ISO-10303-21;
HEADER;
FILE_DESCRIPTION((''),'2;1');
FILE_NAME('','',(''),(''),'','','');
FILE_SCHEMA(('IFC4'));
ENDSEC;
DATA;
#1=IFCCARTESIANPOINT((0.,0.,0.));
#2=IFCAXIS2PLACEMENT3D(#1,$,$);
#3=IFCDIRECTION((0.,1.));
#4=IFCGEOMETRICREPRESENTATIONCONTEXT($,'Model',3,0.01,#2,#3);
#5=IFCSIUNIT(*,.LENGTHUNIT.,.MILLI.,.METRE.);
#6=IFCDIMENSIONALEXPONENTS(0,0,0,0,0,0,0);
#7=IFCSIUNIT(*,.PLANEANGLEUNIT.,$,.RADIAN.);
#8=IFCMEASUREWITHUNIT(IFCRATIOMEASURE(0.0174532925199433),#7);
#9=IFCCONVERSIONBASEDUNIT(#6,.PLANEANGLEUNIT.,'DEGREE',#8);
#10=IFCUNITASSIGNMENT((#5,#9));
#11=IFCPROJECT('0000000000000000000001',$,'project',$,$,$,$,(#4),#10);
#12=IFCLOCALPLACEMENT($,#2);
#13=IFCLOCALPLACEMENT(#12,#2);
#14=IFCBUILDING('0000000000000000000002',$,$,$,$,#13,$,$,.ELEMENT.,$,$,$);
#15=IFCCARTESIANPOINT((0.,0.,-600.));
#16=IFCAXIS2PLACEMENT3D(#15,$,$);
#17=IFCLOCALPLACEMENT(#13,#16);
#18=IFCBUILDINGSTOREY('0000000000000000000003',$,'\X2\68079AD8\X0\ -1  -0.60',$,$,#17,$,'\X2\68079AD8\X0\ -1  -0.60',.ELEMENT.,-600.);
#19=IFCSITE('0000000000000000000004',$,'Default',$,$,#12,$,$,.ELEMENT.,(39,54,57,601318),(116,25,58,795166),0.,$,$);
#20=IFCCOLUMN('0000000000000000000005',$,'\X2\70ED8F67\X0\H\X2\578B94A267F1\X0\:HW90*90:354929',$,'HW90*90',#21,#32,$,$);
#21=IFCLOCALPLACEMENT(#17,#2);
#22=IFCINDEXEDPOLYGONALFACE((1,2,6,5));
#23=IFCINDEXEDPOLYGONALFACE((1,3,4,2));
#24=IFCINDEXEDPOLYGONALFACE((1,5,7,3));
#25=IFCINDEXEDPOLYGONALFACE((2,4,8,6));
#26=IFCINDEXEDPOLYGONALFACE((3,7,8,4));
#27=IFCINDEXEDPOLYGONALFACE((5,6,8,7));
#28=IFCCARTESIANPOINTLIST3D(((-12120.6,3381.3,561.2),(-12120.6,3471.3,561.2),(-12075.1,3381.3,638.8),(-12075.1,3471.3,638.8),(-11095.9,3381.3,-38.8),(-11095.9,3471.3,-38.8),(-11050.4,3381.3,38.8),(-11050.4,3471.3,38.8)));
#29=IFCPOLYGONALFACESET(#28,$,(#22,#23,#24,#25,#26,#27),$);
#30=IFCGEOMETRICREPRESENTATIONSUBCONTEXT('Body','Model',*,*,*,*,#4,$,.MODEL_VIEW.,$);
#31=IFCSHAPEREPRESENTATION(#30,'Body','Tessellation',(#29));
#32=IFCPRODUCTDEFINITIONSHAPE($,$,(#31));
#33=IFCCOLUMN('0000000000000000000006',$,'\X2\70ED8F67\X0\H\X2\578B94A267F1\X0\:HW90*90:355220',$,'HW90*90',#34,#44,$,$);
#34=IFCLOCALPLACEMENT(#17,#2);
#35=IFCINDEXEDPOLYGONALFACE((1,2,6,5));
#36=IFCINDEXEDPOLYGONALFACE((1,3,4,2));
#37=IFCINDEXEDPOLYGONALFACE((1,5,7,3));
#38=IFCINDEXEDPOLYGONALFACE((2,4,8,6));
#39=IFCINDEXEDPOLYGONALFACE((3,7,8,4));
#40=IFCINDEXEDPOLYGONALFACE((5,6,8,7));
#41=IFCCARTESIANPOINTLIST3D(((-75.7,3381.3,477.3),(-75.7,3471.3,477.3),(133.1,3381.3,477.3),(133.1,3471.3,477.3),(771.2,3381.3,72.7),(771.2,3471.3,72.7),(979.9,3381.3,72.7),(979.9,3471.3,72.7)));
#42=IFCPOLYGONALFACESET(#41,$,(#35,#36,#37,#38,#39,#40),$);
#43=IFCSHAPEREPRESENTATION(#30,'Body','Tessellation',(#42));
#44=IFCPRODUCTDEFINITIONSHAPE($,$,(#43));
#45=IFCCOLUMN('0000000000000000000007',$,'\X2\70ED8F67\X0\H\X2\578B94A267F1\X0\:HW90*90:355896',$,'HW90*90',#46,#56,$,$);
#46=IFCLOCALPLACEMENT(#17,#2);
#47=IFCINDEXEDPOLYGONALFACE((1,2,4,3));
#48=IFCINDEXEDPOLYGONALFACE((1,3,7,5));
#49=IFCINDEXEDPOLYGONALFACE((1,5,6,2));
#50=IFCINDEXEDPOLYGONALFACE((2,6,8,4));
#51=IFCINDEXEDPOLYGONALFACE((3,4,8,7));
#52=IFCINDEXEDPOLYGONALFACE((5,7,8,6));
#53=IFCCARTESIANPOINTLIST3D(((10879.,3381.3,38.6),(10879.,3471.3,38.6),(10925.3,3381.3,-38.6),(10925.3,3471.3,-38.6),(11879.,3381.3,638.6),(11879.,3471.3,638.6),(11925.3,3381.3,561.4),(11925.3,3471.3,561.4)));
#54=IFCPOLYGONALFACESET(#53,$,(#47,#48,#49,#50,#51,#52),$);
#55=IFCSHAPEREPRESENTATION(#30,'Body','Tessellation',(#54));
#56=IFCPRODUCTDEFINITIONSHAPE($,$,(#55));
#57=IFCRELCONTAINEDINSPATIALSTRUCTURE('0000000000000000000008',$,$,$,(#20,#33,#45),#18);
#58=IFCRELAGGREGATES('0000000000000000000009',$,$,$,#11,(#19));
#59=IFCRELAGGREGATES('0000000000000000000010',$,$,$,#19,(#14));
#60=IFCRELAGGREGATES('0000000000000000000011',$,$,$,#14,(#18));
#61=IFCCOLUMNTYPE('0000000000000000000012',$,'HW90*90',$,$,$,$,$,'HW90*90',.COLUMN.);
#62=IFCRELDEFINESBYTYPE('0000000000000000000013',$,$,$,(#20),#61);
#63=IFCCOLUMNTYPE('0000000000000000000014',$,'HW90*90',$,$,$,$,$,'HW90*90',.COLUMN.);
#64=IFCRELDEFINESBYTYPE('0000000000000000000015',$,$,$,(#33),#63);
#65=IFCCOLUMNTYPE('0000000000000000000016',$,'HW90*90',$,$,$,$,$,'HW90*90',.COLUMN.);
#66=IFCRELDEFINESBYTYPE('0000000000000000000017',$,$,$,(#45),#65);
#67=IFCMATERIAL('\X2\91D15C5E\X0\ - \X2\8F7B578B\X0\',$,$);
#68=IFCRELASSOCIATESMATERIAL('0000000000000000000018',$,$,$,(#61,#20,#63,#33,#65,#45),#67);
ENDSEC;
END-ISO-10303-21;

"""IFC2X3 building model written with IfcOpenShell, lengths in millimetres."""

from ifc_helpers import new_model, entity, si_unit, converted_unit, direction, frame, frame_2d, origin, origin_2d_with_axis, place, context, subcontext, project, spatial, rectangle, extrude, clip, halfspace, source, transform, mapped, material, type_object, type_shapes, element, save


model = new_model("IFC2X3")

# Units and contexts
model_context = context("Model", 3, precision=0.01, world=origin(), true_north=direction((0.0, 1.0)))
body_context = subcontext(model_context, "Body", "Model", "MODEL_VIEW")
ifc_project = project(units=[si_unit("LENGTHUNIT", "METRE", prefix="MILLI"), converted_unit("PLANEANGLEUNIT", "DEGREE", entity("IfcRatioMeasure", 0.0174532925199433), si_unit("PLANEANGLEUNIT", "RADIAN"), dimensions=[0, 0, 0, 0, 0, 0, 0])], contexts=[model_context])

# Site, building, storey
site_placement = place(None, origin())
site = spatial("IfcSite", under=ifc_project, at=site_placement, Name="Default", CompositionType="ELEMENT", RefLatitude=(39, 54, 57, 601318), RefLongitude=(116, 25, 58, 795166), RefElevation=0.0)
building_placement = place(site_placement, origin())
building = spatial("IfcBuilding", under=site, at=building_placement, CompositionType="ELEMENT")
storey_placement = place(building_placement, frame((0.0, 0.0, -600.0)))
storey = spatial("IfcBuildingStorey", under=building, at=storey_placement, Name="标高 -1  -0.60", LongName="标高 -1  -0.60", CompositionType="ELEMENT", Elevation=-600.0)

# Columns
ifc_material = material(Name="金属 - 轻型")
column_type_1 = type_object("IfcColumnType", Name="HW90*90", ElementType="HW90*90", PredefinedType="COLUMN", material=ifc_material)
shared_shape_1 = source(origin(), body_context, "Body", "SweptSolid", [
    extrude(rectangle(XDim=1187.4, YDim=90.0, at=origin_2d_with_axis()), frame((-11608.3, 3426.3, -338.8), z_axis=(0.505291, 0.0, 0.862949), x_axis=(0.862949, 0.0, -0.505291)), (0.0, 0.0, 1.0), 90.0),
])
type_shapes(column_type_1, [shared_shape_1])
column_1_placement = place(storey_placement, frame((0.0, 0.0, 600.0)))
element("IfcColumn", 1, at=column_1_placement, inside=storey, type_object=column_type_1, material=ifc_material, Name="热轧H型钢柱:HW90*90:354929", ObjectType="HW90*90", context=body_context, shape_type="MappedRepresentation", body=[
    mapped(shared_shape_1, transform((0.0, 0.0, 0.0), scale=1.0)),
])
column_type_2 = type_object("IfcColumnType", Name="HW90*90", ElementType="HW90*90", PredefinedType="COLUMN", material=ifc_material)
shared_shape_2 = source(origin(), body_context, "Body", "Clipping", [
    clip(clip(extrude(rectangle(XDim=90.0, YDim=1055.6, at=frame_2d((0.0, 0.0), x_axis=(1.0, 0.0))), frame((452.1, 3426.3, -527.3), z_axis=(0.0, 0.0, 1.0), x_axis=(0.0, -1.0, 0.0)), (0.0, 0.0, 1.0), 404.6), halfspace(frame((-218.3, 3381.3, 45.2), z_axis=(0.431101, 0.0, 0.902304), x_axis=(0.902304, 0.0, -0.431101)), False)), halfspace(frame((-257.1, 3471.3, -36.0), z_axis=(-0.431101, 0.0, -0.902304), x_axis=(0.902304, 0.0, -0.431101)), False)),
])
type_shapes(column_type_2, [shared_shape_2])
column_2_placement = place(storey_placement, frame((0.0, 0.0, 600.0)))
element("IfcColumn", 2, at=column_2_placement, inside=storey, type_object=column_type_2, material=ifc_material, Name="热轧H型钢柱:HW90*90:355220", ObjectType="HW90*90", context=body_context, shape_type="MappedRepresentation", body=[
    mapped(shared_shape_2, transform((0.0, 0.0, 0.0), scale=1.0)),
])
column_type_3 = type_object("IfcColumnType", Name="HW90*90", ElementType="HW90*90", PredefinedType="COLUMN", material=ifc_material)
shared_shape_3 = source(origin(), body_context, "Body", "SweptSolid", [
    extrude(rectangle(XDim=1166.2, YDim=90.0, at=frame_2d((0.0, 0.0), x_axis=(1.0, 0.0))), frame((11425.3, 3426.3, -338.6), z_axis=(-0.514496, 0.0, 0.857493), x_axis=(-0.857493, 0.0, -0.514496)), (0.0, 0.0, 1.0), 90.0),
])
type_shapes(column_type_3, [shared_shape_3])
column_3_placement = place(storey_placement, frame((0.0, 0.0, 600.0)))
element("IfcColumn", 3, at=column_3_placement, inside=storey, type_object=column_type_3, material=ifc_material, Name="热轧H型钢柱:HW90*90:355896", ObjectType="HW90*90", context=body_context, shape_type="MappedRepresentation", body=[
    mapped(shared_shape_3, transform((0.0, 0.0, 0.0), scale=1.0)),
])

save(model, "model.ifc")
